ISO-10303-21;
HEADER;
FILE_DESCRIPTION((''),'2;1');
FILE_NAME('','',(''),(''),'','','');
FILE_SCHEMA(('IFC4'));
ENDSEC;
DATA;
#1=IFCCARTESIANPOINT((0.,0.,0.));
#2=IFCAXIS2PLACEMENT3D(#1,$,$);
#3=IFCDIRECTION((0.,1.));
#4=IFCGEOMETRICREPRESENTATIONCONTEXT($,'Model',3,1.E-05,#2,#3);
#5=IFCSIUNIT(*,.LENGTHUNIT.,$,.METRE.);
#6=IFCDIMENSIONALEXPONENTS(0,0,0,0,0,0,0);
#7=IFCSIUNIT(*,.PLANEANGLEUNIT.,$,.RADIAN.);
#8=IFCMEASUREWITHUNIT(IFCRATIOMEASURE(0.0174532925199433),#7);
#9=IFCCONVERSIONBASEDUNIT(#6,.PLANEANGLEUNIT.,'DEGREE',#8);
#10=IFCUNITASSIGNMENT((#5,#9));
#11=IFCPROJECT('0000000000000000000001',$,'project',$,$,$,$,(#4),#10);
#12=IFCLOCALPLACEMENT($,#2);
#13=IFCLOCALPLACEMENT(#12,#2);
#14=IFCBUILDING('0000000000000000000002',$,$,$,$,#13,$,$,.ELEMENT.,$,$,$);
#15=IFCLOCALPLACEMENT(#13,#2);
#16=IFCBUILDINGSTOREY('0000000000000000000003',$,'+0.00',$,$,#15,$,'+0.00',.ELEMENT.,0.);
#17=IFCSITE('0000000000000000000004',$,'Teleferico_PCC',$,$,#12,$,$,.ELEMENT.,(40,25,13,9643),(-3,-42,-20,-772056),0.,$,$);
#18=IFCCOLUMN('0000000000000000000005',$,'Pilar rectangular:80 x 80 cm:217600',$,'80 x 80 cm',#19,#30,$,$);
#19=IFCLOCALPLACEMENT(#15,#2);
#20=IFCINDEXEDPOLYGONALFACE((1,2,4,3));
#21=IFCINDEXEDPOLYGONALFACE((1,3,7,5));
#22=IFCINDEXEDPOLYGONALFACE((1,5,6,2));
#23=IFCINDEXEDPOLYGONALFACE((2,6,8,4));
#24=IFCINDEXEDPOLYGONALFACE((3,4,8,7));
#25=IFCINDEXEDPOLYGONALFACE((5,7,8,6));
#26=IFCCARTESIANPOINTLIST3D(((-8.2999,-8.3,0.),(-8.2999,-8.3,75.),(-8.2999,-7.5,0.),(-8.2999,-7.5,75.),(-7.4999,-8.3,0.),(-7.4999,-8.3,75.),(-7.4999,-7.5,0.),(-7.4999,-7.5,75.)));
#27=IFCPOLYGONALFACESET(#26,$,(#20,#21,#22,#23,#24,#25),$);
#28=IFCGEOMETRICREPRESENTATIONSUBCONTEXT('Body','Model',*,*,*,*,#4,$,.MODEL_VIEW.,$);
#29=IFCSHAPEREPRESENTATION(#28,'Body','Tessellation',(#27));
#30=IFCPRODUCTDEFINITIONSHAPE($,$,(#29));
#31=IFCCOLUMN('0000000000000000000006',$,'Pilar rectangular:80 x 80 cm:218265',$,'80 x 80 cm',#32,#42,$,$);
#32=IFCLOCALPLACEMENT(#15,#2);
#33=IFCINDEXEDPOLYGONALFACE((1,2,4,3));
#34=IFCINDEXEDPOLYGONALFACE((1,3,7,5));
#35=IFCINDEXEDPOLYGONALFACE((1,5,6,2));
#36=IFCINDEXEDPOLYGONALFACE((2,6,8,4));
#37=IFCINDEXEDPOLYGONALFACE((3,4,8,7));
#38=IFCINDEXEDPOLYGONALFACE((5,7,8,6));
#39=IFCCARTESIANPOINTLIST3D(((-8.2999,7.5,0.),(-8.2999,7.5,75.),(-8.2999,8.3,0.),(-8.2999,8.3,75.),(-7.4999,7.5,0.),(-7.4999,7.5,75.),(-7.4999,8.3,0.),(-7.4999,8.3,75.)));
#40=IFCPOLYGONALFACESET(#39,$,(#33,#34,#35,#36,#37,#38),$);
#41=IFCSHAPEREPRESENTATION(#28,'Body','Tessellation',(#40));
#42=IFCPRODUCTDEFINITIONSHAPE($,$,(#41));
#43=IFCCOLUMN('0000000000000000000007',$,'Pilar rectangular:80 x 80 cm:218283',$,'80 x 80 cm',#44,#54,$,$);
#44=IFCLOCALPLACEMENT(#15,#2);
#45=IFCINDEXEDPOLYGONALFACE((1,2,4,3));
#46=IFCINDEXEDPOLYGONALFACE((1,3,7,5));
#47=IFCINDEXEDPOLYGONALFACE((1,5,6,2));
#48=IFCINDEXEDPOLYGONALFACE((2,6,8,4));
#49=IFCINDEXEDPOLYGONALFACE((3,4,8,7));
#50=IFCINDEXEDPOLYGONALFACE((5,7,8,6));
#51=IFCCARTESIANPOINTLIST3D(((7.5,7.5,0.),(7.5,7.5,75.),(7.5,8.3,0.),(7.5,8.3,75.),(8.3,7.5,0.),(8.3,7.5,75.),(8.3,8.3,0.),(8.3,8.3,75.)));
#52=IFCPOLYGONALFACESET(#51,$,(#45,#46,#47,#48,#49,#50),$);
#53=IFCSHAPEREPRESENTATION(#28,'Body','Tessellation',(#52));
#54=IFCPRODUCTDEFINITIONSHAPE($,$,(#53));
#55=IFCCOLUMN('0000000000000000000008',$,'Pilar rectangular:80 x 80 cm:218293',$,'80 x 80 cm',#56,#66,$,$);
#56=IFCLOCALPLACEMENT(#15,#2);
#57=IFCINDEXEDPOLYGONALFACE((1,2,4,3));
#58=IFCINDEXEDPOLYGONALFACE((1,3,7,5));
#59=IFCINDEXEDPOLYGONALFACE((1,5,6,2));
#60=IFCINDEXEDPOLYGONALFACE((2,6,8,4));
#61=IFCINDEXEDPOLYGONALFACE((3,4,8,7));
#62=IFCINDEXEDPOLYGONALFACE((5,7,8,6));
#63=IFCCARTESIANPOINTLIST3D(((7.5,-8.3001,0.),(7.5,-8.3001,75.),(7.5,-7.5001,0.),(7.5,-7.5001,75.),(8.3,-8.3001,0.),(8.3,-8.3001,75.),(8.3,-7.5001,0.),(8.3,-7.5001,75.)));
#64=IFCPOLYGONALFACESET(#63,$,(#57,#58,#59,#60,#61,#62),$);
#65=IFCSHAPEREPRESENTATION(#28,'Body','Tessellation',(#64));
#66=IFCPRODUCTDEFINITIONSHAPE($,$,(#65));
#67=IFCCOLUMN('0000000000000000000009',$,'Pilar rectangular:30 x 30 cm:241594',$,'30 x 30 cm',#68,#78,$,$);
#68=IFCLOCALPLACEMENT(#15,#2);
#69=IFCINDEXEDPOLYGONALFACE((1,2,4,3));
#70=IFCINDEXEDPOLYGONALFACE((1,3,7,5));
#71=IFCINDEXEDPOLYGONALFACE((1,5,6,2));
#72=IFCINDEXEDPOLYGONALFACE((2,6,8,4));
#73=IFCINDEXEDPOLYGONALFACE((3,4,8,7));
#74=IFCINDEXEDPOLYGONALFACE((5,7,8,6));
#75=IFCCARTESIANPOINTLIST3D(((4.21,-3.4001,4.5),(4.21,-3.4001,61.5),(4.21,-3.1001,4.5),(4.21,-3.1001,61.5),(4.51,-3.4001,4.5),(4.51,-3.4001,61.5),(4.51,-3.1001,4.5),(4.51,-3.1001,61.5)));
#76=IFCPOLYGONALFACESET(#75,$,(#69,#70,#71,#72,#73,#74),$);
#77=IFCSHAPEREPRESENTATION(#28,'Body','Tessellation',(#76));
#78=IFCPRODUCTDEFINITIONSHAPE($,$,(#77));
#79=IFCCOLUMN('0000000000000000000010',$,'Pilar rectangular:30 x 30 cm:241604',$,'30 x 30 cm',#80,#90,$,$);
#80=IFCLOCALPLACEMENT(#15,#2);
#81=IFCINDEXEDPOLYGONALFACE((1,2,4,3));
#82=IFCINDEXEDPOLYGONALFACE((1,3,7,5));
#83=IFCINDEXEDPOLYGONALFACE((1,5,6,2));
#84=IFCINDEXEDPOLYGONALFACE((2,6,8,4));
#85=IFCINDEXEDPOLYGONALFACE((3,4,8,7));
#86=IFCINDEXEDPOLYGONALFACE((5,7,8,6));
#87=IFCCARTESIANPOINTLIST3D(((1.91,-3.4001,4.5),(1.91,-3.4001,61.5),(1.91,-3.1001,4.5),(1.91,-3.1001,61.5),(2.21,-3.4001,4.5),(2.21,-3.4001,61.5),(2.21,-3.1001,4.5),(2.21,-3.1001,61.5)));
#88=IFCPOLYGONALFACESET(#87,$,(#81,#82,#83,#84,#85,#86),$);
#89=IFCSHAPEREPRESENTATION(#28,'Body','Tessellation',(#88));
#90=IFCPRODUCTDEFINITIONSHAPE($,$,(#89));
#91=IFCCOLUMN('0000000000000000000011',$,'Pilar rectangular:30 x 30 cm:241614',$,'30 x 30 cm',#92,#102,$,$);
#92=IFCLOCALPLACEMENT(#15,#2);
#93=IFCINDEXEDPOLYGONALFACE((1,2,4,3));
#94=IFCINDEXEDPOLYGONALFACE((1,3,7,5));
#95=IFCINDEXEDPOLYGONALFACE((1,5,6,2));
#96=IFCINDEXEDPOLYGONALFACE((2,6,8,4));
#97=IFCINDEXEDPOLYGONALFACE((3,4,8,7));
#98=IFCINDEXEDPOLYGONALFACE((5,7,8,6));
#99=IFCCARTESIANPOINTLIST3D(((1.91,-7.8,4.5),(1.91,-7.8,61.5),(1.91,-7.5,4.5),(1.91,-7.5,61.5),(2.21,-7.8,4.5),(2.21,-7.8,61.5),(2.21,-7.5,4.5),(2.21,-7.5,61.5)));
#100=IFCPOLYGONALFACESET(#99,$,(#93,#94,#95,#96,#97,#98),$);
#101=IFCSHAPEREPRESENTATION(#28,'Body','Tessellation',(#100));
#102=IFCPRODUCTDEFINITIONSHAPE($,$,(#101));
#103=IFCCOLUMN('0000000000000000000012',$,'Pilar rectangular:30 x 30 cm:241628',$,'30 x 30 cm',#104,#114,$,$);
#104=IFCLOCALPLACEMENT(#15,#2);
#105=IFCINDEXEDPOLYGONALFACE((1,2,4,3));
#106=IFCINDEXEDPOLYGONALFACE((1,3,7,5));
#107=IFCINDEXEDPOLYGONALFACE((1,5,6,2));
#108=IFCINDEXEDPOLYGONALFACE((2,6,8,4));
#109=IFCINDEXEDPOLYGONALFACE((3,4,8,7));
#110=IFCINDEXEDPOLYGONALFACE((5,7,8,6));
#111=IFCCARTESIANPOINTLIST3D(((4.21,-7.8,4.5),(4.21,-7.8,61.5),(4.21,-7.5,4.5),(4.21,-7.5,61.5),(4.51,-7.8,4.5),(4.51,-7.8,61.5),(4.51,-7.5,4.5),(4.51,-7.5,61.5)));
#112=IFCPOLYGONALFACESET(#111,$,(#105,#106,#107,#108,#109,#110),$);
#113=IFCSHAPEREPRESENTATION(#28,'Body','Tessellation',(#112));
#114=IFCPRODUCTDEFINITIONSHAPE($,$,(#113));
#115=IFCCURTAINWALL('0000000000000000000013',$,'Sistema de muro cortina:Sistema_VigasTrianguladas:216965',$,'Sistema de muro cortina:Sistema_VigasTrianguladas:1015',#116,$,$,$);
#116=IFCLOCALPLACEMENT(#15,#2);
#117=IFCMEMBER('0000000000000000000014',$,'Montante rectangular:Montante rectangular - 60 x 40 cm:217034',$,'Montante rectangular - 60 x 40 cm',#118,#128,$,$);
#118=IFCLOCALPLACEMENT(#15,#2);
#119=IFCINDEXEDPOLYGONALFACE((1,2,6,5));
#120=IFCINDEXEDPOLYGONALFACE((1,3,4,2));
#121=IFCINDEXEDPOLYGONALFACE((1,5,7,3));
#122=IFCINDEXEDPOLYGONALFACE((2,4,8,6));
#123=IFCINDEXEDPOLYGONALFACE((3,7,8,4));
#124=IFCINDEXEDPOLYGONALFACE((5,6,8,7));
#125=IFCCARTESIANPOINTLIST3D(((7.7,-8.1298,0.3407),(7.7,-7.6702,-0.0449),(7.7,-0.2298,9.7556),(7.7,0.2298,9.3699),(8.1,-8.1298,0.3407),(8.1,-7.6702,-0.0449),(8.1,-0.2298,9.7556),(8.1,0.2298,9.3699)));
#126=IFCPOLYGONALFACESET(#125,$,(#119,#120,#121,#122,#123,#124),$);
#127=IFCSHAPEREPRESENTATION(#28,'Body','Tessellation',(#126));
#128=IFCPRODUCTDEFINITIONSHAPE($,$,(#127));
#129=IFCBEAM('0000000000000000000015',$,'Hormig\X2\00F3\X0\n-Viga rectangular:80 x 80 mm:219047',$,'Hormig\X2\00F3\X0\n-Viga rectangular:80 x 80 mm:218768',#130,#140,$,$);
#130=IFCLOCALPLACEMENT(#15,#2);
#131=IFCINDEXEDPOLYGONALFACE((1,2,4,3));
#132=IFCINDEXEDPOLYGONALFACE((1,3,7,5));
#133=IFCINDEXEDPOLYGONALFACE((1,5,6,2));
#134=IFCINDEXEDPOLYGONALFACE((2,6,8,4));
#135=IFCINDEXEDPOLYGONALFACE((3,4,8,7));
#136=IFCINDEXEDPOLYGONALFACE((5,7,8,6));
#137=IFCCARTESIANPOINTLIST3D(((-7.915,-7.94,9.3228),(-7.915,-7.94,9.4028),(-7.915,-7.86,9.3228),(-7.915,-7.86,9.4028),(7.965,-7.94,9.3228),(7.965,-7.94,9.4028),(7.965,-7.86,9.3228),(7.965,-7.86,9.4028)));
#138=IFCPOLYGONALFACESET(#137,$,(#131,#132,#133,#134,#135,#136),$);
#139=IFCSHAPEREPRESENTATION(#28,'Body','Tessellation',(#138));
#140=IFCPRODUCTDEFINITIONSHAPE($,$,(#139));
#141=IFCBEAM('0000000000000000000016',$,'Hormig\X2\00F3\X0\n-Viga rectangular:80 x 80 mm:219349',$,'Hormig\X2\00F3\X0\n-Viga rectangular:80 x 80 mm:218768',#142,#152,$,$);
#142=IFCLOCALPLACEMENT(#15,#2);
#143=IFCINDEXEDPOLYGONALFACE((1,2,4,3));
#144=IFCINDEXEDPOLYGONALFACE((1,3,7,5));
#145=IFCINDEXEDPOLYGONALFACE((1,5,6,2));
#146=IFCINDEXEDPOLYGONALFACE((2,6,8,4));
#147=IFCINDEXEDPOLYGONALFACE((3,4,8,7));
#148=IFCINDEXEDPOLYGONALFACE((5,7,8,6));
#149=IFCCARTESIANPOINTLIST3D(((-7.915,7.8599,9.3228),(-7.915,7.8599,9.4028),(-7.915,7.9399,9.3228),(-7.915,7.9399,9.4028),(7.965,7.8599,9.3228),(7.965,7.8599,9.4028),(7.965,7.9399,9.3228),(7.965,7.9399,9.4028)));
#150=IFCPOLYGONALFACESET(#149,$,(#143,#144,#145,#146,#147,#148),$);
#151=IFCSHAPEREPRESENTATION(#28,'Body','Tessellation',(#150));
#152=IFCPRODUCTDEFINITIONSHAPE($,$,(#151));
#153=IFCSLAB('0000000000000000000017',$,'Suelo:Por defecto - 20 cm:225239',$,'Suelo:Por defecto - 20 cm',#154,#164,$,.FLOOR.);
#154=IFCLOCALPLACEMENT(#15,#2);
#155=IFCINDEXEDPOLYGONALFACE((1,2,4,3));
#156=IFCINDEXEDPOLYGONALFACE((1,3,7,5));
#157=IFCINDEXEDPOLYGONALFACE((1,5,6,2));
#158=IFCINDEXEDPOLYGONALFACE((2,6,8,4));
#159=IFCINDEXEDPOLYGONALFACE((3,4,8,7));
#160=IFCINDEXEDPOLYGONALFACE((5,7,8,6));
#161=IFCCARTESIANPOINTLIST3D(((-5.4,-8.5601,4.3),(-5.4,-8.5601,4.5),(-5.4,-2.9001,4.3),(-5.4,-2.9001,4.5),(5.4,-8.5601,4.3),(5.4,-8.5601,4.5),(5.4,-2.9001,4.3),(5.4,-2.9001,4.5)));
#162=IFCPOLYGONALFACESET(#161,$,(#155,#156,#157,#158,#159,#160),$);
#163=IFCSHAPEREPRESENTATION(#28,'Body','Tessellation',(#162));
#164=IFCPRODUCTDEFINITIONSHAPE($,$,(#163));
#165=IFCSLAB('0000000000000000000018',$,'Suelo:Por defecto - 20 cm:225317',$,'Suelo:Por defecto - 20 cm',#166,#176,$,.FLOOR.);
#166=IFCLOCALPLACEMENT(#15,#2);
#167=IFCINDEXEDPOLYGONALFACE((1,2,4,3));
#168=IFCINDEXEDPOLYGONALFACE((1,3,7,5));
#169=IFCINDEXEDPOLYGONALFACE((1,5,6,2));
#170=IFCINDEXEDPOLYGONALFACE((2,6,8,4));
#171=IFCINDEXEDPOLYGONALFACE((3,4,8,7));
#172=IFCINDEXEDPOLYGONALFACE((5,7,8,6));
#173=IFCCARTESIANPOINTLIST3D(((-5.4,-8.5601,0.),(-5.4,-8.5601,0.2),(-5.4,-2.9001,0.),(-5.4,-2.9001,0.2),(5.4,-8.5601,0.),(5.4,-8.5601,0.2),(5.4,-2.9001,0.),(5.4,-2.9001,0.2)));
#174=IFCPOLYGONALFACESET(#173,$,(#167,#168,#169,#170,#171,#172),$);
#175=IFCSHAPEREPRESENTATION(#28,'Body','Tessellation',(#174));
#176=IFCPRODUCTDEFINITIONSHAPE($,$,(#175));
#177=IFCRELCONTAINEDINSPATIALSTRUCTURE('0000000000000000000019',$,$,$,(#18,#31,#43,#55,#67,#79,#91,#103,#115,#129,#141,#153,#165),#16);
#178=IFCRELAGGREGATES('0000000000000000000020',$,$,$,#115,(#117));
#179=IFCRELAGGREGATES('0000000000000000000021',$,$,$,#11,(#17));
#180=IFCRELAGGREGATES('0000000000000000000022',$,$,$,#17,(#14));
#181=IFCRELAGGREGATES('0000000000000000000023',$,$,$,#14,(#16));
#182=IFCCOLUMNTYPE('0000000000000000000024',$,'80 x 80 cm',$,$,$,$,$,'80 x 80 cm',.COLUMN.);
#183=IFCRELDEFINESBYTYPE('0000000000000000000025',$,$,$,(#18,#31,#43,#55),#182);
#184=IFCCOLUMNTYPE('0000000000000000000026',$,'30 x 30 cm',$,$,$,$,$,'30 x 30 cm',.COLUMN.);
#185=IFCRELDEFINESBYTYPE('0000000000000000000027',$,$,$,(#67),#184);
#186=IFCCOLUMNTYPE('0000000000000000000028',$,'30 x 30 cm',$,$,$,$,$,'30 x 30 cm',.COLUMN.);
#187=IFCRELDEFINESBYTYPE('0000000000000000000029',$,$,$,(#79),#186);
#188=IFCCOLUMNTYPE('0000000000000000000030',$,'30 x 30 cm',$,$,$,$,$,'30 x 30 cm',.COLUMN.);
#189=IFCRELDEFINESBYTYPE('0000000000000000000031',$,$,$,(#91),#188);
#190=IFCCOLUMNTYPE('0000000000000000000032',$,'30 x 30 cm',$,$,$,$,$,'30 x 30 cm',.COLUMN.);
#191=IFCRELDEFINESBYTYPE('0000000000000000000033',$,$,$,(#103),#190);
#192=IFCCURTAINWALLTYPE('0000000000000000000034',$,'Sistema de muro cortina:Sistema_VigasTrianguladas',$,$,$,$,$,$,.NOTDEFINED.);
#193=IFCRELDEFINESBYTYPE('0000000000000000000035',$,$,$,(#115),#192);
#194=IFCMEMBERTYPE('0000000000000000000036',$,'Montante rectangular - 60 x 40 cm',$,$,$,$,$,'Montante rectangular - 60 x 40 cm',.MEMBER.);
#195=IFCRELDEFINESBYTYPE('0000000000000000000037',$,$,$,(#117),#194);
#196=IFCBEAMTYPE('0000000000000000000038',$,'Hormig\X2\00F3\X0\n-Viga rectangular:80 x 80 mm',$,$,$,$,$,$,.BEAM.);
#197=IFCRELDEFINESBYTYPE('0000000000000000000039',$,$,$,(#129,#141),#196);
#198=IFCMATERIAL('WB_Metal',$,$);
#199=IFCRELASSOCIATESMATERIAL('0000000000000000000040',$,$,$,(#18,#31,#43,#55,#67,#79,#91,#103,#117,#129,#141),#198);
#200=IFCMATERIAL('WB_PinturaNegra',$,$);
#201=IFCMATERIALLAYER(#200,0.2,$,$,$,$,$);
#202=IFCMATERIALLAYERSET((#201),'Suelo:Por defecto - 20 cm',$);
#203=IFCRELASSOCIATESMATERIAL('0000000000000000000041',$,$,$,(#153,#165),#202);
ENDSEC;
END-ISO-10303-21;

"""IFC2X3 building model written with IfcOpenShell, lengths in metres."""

from ifc_helpers import new_model, entity, si_unit, converted_unit, direction, frame, frame_2d, origin, origin_2d_with_axis, place, context, subcontext, project, spatial, rectangle, extrude, source, transform, mapped, material, layer, layer_set, layer_usage, type_object, type_shapes, element, aggregate, save


model = new_model("IFC2X3")

# Units and contexts
model_context = context("Model", 3, precision=1e-05, world=origin(), true_north=direction((0.0, 1.0)))
body_context = subcontext(model_context, "Body", "Model", "MODEL_VIEW")
ifc_project = project(units=[si_unit("LENGTHUNIT", "METRE"), converted_unit("PLANEANGLEUNIT", "DEGREE", entity("IfcRatioMeasure", 0.0174532925199433), si_unit("PLANEANGLEUNIT", "RADIAN"), dimensions=[0, 0, 0, 0, 0, 0, 0])], contexts=[model_context])

# Site, building, storey
site_placement = place(None, origin())
site = spatial("IfcSite", under=ifc_project, at=site_placement, Name="Teleferico_PCC", CompositionType="ELEMENT", RefLatitude=(40, 25, 13, 9643), RefLongitude=(-3, -42, -20, -772056), RefElevation=0.0)
building_placement = place(site_placement, origin())
building = spatial("IfcBuilding", under=site, at=building_placement, CompositionType="ELEMENT")
storey_placement = place(building_placement, origin())
storey = spatial("IfcBuildingStorey", under=building, at=storey_placement, Name="+0.00", LongName="+0.00", CompositionType="ELEMENT", Elevation=0.0)

# Columns
ifc_material_1 = material(Name="WB_Metal")
column_type_1 = type_object("IfcColumnType", Name="80 x 80 cm", ElementType="80 x 80 cm", PredefinedType="COLUMN")
shared_shape_1 = source(origin(), body_context, "Body", "SweptSolid", [
    extrude(rectangle(XDim=0.8, YDim=0.8, at=origin_2d_with_axis()), frame((0.0, 0.0, 0.0), z_axis=(0.0, 0.0, 1.0), x_axis=(0.0, -1.0, 0.0)), (0.0, 0.0, 1.0), 75.0),
])
type_shapes(column_type_1, [shared_shape_1])
for number, where, name in (
    (1, (-7.8999, -7.9, 0.0), "Pilar rectangular:80 x 80 cm:217600"),
    (2, (-7.8999, 7.9, 0.0), "Pilar rectangular:80 x 80 cm:218265"),
    (3, (7.9, 7.9, 0.0), "Pilar rectangular:80 x 80 cm:218283"),
    (4, (7.9, -7.9001, 0.0), "Pilar rectangular:80 x 80 cm:218293"),
):
    element("IfcColumn", number, at=place(storey_placement, frame(where)), inside=storey, type_object=column_type_1, material=ifc_material_1, Name=name, ObjectType="80 x 80 cm", context=body_context, shape_type="MappedRepresentation", body=[
        mapped(shared_shape_1, transform((0.0, 0.0, 0.0), scale=1.0)),
    ])
column_type_2 = type_object("IfcColumnType", Name="30 x 30 cm", ElementType="30 x 30 cm", PredefinedType="COLUMN")
shared_shape_2 = source(origin(), body_context, "Body", "SweptSolid", [
    extrude(rectangle(XDim=0.3, YDim=0.3, at=origin_2d_with_axis()), frame((4.36, -3.2501, 4.5), z_axis=(0.0, 0.0, 1.0), x_axis=(0.0, -1.0, 0.0)), (0.0, 0.0, 1.0), 57.0),
])
type_shapes(column_type_2, [shared_shape_2])
column_1_placement = place(storey_placement, origin())
element("IfcColumn", 5, at=column_1_placement, inside=storey, type_object=column_type_2, material=ifc_material_1, Name="Pilar rectangular:30 x 30 cm:241594", ObjectType="30 x 30 cm", context=body_context, shape_type="MappedRepresentation", body=[
    mapped(shared_shape_2, transform((0.0, 0.0, 0.0), scale=1.0)),
])
column_type_3 = type_object("IfcColumnType", Name="30 x 30 cm", ElementType="30 x 30 cm", PredefinedType="COLUMN")
shared_shape_3 = source(origin(), body_context, "Body", "SweptSolid", [
    extrude(rectangle(XDim=0.3, YDim=0.3, at=frame_2d((0.0, 0.0), x_axis=(1.0, 0.0))), frame((2.06, -3.2501, 4.5), z_axis=(0.0, 0.0, 1.0), x_axis=(0.0, -1.0, 0.0)), (0.0, 0.0, 1.0), 57.0),
])
type_shapes(column_type_3, [shared_shape_3])
column_2_placement = place(storey_placement, origin())
element("IfcColumn", 6, at=column_2_placement, inside=storey, type_object=column_type_3, material=ifc_material_1, Name="Pilar rectangular:30 x 30 cm:241604", ObjectType="30 x 30 cm", context=body_context, shape_type="MappedRepresentation", body=[
    mapped(shared_shape_3, transform((0.0, 0.0, 0.0), scale=1.0)),
])
column_type_4 = type_object("IfcColumnType", Name="30 x 30 cm", ElementType="30 x 30 cm", PredefinedType="COLUMN")
shared_shape_4 = source(origin(), body_context, "Body", "SweptSolid", [
    extrude(rectangle(XDim=0.3, YDim=0.3, at=frame_2d((0.0, 0.0), x_axis=(1.0, 0.0))), frame((2.06, -7.65, 4.5), z_axis=(0.0, 0.0, 1.0), x_axis=(0.0, -1.0, 0.0)), (0.0, 0.0, 1.0), 57.0),
])
type_shapes(column_type_4, [shared_shape_4])
column_3_placement = place(storey_placement, origin())
element("IfcColumn", 7, at=column_3_placement, inside=storey, type_object=column_type_4, material=ifc_material_1, Name="Pilar rectangular:30 x 30 cm:241614", ObjectType="30 x 30 cm", context=body_context, shape_type="MappedRepresentation", body=[
    mapped(shared_shape_4, transform((0.0, 0.0, 0.0), scale=1.0)),
])
column_type_5 = type_object("IfcColumnType", Name="30 x 30 cm", ElementType="30 x 30 cm", PredefinedType="COLUMN")
shared_shape_5 = source(origin(), body_context, "Body", "SweptSolid", [
    extrude(rectangle(XDim=0.3, YDim=0.3, at=frame_2d((0.0, 0.0), x_axis=(1.0, 0.0))), frame((4.36, -7.65, 4.5), z_axis=(0.0, 0.0, 1.0), x_axis=(0.0, -1.0, 0.0)), (0.0, 0.0, 1.0), 57.0),
])
type_shapes(column_type_5, [shared_shape_5])
column_4_placement = place(storey_placement, origin())
element("IfcColumn", 8, at=column_4_placement, inside=storey, type_object=column_type_5, material=ifc_material_1, Name="Pilar rectangular:30 x 30 cm:241628", ObjectType="30 x 30 cm", context=body_context, shape_type="MappedRepresentation", body=[
    mapped(shared_shape_5, transform((0.0, 0.0, 0.0), scale=1.0)),
])

# Curtain wall, member
curtain_wall_type = type_object("IfcCurtainWallType", Name="Sistema de muro cortina:Sistema_VigasTrianguladas", PredefinedType="NOTDEFINED")
curtain_wall_1_placement = place(storey_placement, origin())
curtain_wall_1 = element("IfcCurtainWall", 9, at=curtain_wall_1_placement, inside=storey, type_object=curtain_wall_type, Name="Sistema de muro cortina:Sistema_VigasTrianguladas:216965", ObjectType="Sistema de muro cortina:Sistema_VigasTrianguladas:1015")
member_type_1 = type_object("IfcMemberType", Name="Montante rectangular - 60 x 40 cm", ElementType="Montante rectangular - 60 x 40 cm", PredefinedType="MEMBER")
shared_shape_6 = source(origin(), body_context, "Body", "SweptSolid", [
    extrude(rectangle(XDim=0.4, YDim=0.6, at=frame_2d((0.0, 0.0), x_axis=(1.0, 0.0))), frame((0.0, 0.0, -12.2902), z_axis=(0.0, 0.0, 1.0), x_axis=(0.0, -1.0, 0.0)), (0.0, 0.0, 1.0), 12.2902),
])
type_shapes(member_type_1, [shared_shape_6])
member_1_placement = place(storey_placement, frame((7.9, 0.0, 9.5628), z_axis=(0.0, 0.642788, 0.766044), x_axis=(0.0, -0.766044, 0.642788)))
member_1 = element("IfcMember", 10, at=member_1_placement, type_object=member_type_1, material=ifc_material_1, Name="Montante rectangular:Montante rectangular - 60 x 40 cm:217034", ObjectType="Montante rectangular - 60 x 40 cm", context=body_context, shape_type="MappedRepresentation", body=[
    mapped(shared_shape_6, transform((0.0, 0.0, 0.0), scale=1.0)),
])

aggregate(curtain_wall_1, [member_1])

# Beams
beam_type = type_object("IfcBeamType", Name="Hormigón-Viga rectangular:80 x 80 mm", PredefinedType="BEAM")
beam_1_placement = place(storey_placement, frame((-7.875, -7.9, 9.3628)))
element("IfcBeam", 11, at=beam_1_placement, inside=storey, type_object=beam_type, material=ifc_material_1, Name="Hormigón-Viga rectangular:80 x 80 mm:219047", ObjectType="Hormigón-Viga rectangular:80 x 80 mm:218768", context=body_context, shape_type="SweptSolid", body=[
    extrude(rectangle(XDim=0.08, YDim=0.08, at=frame_2d((0.0, 0.0), x_axis=(1.0, 0.0))), frame((-0.04, 0.0, 0.0), z_axis=(1.0, 0.0, 0.0), x_axis=(0.0, 0.0, -1.0)), (0.0, 0.0, 1.0), 15.88),
])
beam_2_placement = place(storey_placement, frame((-7.875, 7.8999, 9.3628)))
element("IfcBeam", 12, at=beam_2_placement, inside=storey, type_object=beam_type, material=ifc_material_1, Name="Hormigón-Viga rectangular:80 x 80 mm:219349", ObjectType="Hormigón-Viga rectangular:80 x 80 mm:218768", context=body_context, shape_type="SweptSolid", body=[
    extrude(rectangle(XDim=0.08, YDim=0.08, at=frame_2d((0.0, 0.0), x_axis=(1.0, 0.0))), frame((-0.04, 0.0, 0.0), z_axis=(1.0, 0.0, 0.0), x_axis=(0.0, 0.0, -1.0)), (0.0, 0.0, 1.0), 15.88),
])

# Slabs
ifc_material_2 = material(Name="WB_PinturaNegra")
ifc_layer_1 = layer(ifc_material_2, 0.2)
ifc_layer_set_1 = layer_set([ifc_layer_1], Name="Suelo:Por defecto - 20 cm")
ifc_layer_usage_1 = layer_usage(ifc_layer_set_1, "AXIS3", "POSITIVE", 0.0)
slab_1_placement = place(storey_placement, origin())
element("IfcSlab", 13, at=slab_1_placement, inside=storey, material=ifc_layer_usage_1, Name="Suelo:Por defecto - 20 cm:225239", ObjectType="Suelo:Por defecto - 20 cm", PredefinedType="FLOOR", context=body_context, shape_type="SweptSolid", body=[
    extrude(rectangle(XDim=5.66, YDim=10.8, at=origin_2d_with_axis()), frame((0.0, -5.7301, 4.5), z_axis=(0.0, 0.0, -1.0), x_axis=(0.0, 1.0, 0.0)), (0.0, 0.0, 1.0), 0.2),
])
ifc_layer_usage_2 = layer_usage(ifc_layer_set_1, "AXIS3", "POSITIVE", 0.0)
slab_2_placement = place(storey_placement, origin())
element("IfcSlab", 14, at=slab_2_placement, inside=storey, material=ifc_layer_usage_2, Name="Suelo:Por defecto - 20 cm:225317", ObjectType="Suelo:Por defecto - 20 cm", PredefinedType="FLOOR", context=body_context, shape_type="SweptSolid", body=[
    extrude(rectangle(XDim=5.66, YDim=10.8, at=origin_2d_with_axis()), frame((0.0, -5.7301, 0.2), z_axis=(0.0, 0.0, -1.0), x_axis=(0.0, 1.0, 0.0)), (0.0, 0.0, 1.0), 0.2),
])

save(model, "model.ifc")
